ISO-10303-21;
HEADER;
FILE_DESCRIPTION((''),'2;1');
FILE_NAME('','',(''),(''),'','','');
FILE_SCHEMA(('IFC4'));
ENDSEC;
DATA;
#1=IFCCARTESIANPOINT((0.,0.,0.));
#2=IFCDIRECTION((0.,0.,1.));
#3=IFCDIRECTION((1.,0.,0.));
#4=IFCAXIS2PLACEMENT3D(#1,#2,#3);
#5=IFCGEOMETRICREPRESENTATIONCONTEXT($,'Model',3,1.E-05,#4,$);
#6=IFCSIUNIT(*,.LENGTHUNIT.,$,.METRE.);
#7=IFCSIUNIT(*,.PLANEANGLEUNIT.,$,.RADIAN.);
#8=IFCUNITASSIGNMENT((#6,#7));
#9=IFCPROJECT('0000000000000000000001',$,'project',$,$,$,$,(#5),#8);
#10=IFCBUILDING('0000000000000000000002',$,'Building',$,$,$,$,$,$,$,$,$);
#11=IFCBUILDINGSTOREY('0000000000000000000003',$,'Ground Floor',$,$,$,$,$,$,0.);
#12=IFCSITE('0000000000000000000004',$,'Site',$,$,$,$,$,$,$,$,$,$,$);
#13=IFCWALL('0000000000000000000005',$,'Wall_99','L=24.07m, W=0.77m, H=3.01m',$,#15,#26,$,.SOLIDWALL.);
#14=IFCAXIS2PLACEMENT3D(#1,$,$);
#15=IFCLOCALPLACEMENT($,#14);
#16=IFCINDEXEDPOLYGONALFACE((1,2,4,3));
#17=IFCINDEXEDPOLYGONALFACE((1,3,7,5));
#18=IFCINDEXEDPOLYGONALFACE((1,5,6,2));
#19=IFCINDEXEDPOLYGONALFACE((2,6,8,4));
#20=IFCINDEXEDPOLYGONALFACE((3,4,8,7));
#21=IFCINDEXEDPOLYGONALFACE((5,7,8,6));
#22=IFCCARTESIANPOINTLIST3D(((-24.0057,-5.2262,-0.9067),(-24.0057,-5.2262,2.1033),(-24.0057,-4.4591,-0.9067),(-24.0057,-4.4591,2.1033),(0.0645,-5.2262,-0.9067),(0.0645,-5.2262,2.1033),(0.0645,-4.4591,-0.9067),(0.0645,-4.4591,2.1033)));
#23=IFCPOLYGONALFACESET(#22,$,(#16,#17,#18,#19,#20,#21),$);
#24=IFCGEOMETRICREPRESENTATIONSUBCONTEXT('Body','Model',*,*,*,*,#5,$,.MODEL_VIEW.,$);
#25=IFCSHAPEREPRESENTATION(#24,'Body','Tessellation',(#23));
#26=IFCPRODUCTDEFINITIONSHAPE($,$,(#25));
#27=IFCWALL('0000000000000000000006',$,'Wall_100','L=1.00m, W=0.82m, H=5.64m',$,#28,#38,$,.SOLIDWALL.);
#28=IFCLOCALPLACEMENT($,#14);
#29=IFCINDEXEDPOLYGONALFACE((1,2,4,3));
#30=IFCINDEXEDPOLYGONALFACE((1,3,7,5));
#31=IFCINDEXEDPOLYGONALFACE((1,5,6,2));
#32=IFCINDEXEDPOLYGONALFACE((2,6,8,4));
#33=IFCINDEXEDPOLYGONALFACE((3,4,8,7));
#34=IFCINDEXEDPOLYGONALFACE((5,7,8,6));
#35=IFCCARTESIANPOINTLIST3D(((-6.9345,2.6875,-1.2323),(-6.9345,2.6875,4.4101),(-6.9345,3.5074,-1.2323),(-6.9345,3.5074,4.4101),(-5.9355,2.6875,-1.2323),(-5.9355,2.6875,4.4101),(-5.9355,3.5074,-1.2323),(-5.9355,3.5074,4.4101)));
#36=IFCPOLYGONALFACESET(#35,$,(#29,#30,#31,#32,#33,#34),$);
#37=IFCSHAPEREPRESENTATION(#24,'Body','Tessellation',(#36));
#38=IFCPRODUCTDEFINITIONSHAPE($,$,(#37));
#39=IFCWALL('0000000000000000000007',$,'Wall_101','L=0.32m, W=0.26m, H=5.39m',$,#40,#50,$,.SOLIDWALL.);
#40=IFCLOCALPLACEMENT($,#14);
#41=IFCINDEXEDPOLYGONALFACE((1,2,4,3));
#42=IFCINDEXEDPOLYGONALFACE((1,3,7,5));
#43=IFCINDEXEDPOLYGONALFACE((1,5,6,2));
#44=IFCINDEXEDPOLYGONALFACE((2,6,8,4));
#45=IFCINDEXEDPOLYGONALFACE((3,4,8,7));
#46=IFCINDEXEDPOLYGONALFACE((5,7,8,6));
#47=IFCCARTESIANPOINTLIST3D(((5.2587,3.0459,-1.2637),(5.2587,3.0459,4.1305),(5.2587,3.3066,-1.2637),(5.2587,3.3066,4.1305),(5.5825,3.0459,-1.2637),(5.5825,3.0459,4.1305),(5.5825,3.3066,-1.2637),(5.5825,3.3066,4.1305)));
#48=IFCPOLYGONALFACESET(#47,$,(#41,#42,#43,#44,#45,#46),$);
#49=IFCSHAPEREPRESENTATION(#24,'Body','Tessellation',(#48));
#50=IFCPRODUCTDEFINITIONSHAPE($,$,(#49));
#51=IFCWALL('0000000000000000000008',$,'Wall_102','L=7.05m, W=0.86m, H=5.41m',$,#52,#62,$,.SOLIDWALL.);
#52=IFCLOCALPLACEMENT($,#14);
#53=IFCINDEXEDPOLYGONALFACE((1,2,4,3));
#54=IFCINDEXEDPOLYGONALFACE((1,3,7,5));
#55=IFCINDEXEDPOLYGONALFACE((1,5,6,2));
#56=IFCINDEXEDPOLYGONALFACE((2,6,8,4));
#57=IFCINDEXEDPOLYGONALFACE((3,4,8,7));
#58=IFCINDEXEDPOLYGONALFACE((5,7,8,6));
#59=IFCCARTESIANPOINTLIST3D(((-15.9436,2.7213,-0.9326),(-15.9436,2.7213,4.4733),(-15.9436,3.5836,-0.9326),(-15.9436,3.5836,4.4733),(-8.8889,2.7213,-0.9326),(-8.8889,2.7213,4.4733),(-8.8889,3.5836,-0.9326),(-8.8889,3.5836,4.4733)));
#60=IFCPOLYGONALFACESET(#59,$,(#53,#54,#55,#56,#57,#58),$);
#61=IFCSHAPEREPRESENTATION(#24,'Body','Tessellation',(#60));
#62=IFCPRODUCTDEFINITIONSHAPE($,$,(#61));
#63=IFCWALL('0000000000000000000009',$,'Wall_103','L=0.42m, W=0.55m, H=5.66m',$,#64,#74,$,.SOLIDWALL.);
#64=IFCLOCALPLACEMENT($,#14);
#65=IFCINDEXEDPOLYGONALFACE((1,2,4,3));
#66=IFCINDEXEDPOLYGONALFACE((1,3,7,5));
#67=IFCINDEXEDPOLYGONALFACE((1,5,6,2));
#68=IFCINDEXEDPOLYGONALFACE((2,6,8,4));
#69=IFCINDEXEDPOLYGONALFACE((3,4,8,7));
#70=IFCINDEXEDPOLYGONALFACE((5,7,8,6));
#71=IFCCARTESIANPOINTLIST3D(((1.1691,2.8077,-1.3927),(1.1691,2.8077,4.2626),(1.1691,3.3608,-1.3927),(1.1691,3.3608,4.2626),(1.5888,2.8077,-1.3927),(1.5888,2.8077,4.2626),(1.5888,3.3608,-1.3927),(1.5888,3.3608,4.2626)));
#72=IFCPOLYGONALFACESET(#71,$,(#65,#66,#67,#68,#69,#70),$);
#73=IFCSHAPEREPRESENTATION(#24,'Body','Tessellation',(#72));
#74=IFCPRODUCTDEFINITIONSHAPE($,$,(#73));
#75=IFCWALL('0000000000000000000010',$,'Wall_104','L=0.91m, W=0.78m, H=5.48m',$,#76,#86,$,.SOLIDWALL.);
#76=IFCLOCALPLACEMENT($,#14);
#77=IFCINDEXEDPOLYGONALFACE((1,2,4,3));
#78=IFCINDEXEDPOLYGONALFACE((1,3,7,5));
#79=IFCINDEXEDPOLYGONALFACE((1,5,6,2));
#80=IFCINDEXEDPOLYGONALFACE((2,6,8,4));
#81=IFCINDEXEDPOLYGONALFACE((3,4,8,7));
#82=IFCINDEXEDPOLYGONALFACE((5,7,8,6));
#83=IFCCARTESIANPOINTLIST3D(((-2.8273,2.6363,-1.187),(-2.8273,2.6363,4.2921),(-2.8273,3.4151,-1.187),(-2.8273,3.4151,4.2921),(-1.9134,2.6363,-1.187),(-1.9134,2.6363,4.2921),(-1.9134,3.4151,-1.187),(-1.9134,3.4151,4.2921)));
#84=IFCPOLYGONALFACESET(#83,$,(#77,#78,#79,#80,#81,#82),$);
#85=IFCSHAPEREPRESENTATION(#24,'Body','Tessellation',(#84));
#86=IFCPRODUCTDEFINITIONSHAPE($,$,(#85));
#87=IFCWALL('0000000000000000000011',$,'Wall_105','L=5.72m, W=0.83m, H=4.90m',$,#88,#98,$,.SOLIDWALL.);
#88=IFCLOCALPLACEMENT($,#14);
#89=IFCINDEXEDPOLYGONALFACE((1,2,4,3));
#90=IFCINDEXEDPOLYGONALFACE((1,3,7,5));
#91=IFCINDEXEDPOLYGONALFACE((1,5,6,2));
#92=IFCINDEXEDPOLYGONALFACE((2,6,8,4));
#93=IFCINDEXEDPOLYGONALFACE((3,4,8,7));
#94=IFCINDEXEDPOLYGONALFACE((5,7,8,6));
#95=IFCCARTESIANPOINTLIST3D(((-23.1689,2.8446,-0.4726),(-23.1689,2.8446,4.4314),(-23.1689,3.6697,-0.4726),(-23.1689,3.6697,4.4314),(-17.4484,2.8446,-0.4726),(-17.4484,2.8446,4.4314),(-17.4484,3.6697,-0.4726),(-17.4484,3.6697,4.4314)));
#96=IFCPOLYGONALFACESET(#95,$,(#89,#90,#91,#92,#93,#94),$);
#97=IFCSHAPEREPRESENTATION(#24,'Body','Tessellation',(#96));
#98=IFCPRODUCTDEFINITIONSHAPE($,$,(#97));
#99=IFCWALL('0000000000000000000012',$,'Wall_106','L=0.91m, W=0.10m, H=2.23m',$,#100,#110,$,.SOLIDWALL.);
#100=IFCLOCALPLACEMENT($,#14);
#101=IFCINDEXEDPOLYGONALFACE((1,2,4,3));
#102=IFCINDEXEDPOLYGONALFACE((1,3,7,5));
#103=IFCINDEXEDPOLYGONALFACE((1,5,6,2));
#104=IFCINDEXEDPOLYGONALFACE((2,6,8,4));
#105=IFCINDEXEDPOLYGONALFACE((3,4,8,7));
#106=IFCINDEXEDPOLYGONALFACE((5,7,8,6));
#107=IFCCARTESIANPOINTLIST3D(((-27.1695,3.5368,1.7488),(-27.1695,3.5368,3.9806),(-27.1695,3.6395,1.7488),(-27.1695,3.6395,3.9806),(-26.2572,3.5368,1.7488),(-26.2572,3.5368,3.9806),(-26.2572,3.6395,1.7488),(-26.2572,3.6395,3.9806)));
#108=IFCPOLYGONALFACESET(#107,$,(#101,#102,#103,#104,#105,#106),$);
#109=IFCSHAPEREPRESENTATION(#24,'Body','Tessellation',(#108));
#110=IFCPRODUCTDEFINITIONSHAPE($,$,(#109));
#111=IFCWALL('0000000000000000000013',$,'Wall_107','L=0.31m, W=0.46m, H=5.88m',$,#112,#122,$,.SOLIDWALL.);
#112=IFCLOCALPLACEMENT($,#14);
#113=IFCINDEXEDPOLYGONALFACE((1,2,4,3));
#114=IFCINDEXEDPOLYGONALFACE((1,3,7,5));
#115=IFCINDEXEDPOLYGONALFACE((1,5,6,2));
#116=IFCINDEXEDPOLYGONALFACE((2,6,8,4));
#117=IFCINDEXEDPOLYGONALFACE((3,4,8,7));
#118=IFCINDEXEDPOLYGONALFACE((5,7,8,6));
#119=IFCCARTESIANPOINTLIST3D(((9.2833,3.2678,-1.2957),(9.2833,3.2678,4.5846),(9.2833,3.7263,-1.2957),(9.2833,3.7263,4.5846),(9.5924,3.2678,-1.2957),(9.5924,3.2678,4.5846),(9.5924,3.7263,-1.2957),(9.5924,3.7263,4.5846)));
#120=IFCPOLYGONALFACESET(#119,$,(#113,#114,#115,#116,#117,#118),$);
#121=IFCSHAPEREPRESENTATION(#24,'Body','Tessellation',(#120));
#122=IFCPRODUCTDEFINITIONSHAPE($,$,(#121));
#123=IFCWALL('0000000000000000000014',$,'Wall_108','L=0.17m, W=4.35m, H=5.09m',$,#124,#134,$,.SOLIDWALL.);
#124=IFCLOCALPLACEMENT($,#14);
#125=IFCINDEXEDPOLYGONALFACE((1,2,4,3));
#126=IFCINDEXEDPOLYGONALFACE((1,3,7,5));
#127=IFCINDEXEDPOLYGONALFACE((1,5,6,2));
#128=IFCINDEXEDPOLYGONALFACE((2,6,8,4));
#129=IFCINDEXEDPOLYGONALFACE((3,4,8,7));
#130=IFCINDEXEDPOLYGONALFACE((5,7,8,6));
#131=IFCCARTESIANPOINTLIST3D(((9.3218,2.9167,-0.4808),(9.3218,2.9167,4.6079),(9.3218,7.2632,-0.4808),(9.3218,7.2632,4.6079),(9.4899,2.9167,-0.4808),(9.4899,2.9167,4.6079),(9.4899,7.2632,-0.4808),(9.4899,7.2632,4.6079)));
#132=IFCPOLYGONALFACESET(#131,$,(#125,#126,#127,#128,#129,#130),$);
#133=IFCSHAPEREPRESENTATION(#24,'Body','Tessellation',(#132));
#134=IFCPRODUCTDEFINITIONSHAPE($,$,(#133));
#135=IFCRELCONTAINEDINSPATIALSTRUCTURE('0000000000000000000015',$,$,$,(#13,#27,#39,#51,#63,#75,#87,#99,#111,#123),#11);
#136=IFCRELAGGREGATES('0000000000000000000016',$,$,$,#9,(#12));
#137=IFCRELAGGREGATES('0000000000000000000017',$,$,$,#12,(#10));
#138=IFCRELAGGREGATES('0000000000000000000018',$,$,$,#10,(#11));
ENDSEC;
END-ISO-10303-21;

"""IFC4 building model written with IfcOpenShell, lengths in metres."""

from ifc_helpers import new_model, si_unit, frame, origin_with_axes, origin_2d, context, subcontext, project, spatial, rectangle, extrude, element, save


model = new_model("IFC4")

# Units and contexts
model_context = context("Model", 3, precision=1e-05, world=origin_with_axes())
body_context = subcontext(model_context, "Body", "Model", "MODEL_VIEW")
ifc_project = project(units=[si_unit("LENGTHUNIT", "METRE"), si_unit("PLANEANGLEUNIT", "RADIAN")], contexts=[model_context])

# Site, building, storey
site = spatial("IfcSite", under=ifc_project, Name="Site")
building = spatial("IfcBuilding", under=site, Name="Building")
storey = spatial("IfcBuildingStorey", under=building, Name="Ground Floor", Elevation=0.0)

# Walls
element("IfcWall", 1, inside=storey, Name="Wall_99", Description="L=24.07m, W=0.77m, H=3.01m", PredefinedType="SOLIDWALL", context=body_context, shape_type="SweptSolid", body=[
    extrude(rectangle(XDim=24.0702, YDim=0.7671, at=origin_2d()), frame((-11.9706, -4.8426, -0.9067), z_axis=(0.0, 0.0, 1.0), x_axis=(1.0, 0.0, 0.0)), (0.0, 0.0, 1.0), 3.01),
])
element("IfcWall", 2, inside=storey, Name="Wall_100", Description="L=1.00m, W=0.82m, H=5.64m", PredefinedType="SOLIDWALL", context=body_context, shape_type="SweptSolid", body=[
    extrude(rectangle(XDim=0.999, YDim=0.8198, at=origin_2d()), frame((-6.435, 3.0974, -1.2323), z_axis=(0.0, 0.0, 1.0), x_axis=(1.0, 0.0, 0.0)), (0.0, 0.0, 1.0), 5.6424),
])
element("IfcWall", 3, inside=storey, Name="Wall_101", Description="L=0.32m, W=0.26m, H=5.39m", PredefinedType="SOLIDWALL", context=body_context, shape_type="SweptSolid", body=[
    extrude(rectangle(XDim=0.3237, YDim=0.2606, at=origin_2d()), frame((5.4206, 3.1763, -1.2637), z_axis=(0.0, 0.0, 1.0), x_axis=(1.0, 0.0, 0.0)), (0.0, 0.0, 1.0), 5.3941),
])
element("IfcWall", 4, inside=storey, Name="Wall_102", Description="L=7.05m, W=0.86m, H=5.41m", PredefinedType="SOLIDWALL", context=body_context, shape_type="SweptSolid", body=[
    extrude(rectangle(XDim=7.0547, YDim=0.8623, at=origin_2d()), frame((-12.4163, 3.1524, -0.9326), z_axis=(0.0, 0.0, 1.0), x_axis=(1.0, 0.0, 0.0)), (0.0, 0.0, 1.0), 5.4059),
])
element("IfcWall", 5, inside=storey, Name="Wall_103", Description="L=0.42m, W=0.55m, H=5.66m", PredefinedType="SOLIDWALL", context=body_context, shape_type="SweptSolid", body=[
    extrude(rectangle(XDim=0.4197, YDim=0.5531, at=origin_2d()), frame((1.379, 3.0842, -1.3927), z_axis=(0.0, 0.0, 1.0), x_axis=(1.0, 0.0, 0.0)), (0.0, 0.0, 1.0), 5.6553),
])
element("IfcWall", 6, inside=storey, Name="Wall_104", Description="L=0.91m, W=0.78m, H=5.48m", PredefinedType="SOLIDWALL", context=body_context, shape_type="SweptSolid", body=[
    extrude(rectangle(XDim=0.9138, YDim=0.7788, at=origin_2d()), frame((-2.3703, 3.0257, -1.187), z_axis=(0.0, 0.0, 1.0), x_axis=(1.0, 0.0, 0.0)), (0.0, 0.0, 1.0), 5.4791),
])
element("IfcWall", 7, inside=storey, Name="Wall_105", Description="L=5.72m, W=0.83m, H=4.90m", PredefinedType="SOLIDWALL", context=body_context, shape_type="SweptSolid", body=[
    extrude(rectangle(XDim=5.7205, YDim=0.8251, at=origin_2d()), frame((-20.3086, 3.2571, -0.4726), z_axis=(0.0, 0.0, 1.0), x_axis=(1.0, 0.0, 0.0)), (0.0, 0.0, 1.0), 4.9039),
])
element("IfcWall", 8, inside=storey, Name="Wall_106", Description="L=0.91m, W=0.10m, H=2.23m", PredefinedType="SOLIDWALL", context=body_context, shape_type="SweptSolid", body=[
    extrude(rectangle(XDim=0.9124, YDim=0.1028, at=origin_2d()), frame((-26.7134, 3.5881, 1.7488), z_axis=(0.0, 0.0, 1.0), x_axis=(1.0, 0.0, 0.0)), (0.0, 0.0, 1.0), 2.2317),
])
element("IfcWall", 9, inside=storey, Name="Wall_107", Description="L=0.31m, W=0.46m, H=5.88m", PredefinedType="SOLIDWALL", context=body_context, shape_type="SweptSolid", body=[
    extrude(rectangle(XDim=0.3092, YDim=0.4585, at=origin_2d()), frame((9.4379, 3.497, -1.2957), z_axis=(0.0, 0.0, 1.0), x_axis=(1.0, 0.0, 0.0)), (0.0, 0.0, 1.0), 5.8803),
])
element("IfcWall", 10, inside=storey, Name="Wall_108", Description="L=0.17m, W=4.35m, H=5.09m", PredefinedType="SOLIDWALL", context=body_context, shape_type="SweptSolid", body=[
    extrude(rectangle(XDim=0.1681, YDim=4.3465, at=origin_2d()), frame((9.4059, 5.09, -0.4808), z_axis=(0.0, 0.0, 1.0), x_axis=(1.0, 0.0, 0.0)), (0.0, 0.0, 1.0), 5.0886),
])

save(model, "model.ifc")
